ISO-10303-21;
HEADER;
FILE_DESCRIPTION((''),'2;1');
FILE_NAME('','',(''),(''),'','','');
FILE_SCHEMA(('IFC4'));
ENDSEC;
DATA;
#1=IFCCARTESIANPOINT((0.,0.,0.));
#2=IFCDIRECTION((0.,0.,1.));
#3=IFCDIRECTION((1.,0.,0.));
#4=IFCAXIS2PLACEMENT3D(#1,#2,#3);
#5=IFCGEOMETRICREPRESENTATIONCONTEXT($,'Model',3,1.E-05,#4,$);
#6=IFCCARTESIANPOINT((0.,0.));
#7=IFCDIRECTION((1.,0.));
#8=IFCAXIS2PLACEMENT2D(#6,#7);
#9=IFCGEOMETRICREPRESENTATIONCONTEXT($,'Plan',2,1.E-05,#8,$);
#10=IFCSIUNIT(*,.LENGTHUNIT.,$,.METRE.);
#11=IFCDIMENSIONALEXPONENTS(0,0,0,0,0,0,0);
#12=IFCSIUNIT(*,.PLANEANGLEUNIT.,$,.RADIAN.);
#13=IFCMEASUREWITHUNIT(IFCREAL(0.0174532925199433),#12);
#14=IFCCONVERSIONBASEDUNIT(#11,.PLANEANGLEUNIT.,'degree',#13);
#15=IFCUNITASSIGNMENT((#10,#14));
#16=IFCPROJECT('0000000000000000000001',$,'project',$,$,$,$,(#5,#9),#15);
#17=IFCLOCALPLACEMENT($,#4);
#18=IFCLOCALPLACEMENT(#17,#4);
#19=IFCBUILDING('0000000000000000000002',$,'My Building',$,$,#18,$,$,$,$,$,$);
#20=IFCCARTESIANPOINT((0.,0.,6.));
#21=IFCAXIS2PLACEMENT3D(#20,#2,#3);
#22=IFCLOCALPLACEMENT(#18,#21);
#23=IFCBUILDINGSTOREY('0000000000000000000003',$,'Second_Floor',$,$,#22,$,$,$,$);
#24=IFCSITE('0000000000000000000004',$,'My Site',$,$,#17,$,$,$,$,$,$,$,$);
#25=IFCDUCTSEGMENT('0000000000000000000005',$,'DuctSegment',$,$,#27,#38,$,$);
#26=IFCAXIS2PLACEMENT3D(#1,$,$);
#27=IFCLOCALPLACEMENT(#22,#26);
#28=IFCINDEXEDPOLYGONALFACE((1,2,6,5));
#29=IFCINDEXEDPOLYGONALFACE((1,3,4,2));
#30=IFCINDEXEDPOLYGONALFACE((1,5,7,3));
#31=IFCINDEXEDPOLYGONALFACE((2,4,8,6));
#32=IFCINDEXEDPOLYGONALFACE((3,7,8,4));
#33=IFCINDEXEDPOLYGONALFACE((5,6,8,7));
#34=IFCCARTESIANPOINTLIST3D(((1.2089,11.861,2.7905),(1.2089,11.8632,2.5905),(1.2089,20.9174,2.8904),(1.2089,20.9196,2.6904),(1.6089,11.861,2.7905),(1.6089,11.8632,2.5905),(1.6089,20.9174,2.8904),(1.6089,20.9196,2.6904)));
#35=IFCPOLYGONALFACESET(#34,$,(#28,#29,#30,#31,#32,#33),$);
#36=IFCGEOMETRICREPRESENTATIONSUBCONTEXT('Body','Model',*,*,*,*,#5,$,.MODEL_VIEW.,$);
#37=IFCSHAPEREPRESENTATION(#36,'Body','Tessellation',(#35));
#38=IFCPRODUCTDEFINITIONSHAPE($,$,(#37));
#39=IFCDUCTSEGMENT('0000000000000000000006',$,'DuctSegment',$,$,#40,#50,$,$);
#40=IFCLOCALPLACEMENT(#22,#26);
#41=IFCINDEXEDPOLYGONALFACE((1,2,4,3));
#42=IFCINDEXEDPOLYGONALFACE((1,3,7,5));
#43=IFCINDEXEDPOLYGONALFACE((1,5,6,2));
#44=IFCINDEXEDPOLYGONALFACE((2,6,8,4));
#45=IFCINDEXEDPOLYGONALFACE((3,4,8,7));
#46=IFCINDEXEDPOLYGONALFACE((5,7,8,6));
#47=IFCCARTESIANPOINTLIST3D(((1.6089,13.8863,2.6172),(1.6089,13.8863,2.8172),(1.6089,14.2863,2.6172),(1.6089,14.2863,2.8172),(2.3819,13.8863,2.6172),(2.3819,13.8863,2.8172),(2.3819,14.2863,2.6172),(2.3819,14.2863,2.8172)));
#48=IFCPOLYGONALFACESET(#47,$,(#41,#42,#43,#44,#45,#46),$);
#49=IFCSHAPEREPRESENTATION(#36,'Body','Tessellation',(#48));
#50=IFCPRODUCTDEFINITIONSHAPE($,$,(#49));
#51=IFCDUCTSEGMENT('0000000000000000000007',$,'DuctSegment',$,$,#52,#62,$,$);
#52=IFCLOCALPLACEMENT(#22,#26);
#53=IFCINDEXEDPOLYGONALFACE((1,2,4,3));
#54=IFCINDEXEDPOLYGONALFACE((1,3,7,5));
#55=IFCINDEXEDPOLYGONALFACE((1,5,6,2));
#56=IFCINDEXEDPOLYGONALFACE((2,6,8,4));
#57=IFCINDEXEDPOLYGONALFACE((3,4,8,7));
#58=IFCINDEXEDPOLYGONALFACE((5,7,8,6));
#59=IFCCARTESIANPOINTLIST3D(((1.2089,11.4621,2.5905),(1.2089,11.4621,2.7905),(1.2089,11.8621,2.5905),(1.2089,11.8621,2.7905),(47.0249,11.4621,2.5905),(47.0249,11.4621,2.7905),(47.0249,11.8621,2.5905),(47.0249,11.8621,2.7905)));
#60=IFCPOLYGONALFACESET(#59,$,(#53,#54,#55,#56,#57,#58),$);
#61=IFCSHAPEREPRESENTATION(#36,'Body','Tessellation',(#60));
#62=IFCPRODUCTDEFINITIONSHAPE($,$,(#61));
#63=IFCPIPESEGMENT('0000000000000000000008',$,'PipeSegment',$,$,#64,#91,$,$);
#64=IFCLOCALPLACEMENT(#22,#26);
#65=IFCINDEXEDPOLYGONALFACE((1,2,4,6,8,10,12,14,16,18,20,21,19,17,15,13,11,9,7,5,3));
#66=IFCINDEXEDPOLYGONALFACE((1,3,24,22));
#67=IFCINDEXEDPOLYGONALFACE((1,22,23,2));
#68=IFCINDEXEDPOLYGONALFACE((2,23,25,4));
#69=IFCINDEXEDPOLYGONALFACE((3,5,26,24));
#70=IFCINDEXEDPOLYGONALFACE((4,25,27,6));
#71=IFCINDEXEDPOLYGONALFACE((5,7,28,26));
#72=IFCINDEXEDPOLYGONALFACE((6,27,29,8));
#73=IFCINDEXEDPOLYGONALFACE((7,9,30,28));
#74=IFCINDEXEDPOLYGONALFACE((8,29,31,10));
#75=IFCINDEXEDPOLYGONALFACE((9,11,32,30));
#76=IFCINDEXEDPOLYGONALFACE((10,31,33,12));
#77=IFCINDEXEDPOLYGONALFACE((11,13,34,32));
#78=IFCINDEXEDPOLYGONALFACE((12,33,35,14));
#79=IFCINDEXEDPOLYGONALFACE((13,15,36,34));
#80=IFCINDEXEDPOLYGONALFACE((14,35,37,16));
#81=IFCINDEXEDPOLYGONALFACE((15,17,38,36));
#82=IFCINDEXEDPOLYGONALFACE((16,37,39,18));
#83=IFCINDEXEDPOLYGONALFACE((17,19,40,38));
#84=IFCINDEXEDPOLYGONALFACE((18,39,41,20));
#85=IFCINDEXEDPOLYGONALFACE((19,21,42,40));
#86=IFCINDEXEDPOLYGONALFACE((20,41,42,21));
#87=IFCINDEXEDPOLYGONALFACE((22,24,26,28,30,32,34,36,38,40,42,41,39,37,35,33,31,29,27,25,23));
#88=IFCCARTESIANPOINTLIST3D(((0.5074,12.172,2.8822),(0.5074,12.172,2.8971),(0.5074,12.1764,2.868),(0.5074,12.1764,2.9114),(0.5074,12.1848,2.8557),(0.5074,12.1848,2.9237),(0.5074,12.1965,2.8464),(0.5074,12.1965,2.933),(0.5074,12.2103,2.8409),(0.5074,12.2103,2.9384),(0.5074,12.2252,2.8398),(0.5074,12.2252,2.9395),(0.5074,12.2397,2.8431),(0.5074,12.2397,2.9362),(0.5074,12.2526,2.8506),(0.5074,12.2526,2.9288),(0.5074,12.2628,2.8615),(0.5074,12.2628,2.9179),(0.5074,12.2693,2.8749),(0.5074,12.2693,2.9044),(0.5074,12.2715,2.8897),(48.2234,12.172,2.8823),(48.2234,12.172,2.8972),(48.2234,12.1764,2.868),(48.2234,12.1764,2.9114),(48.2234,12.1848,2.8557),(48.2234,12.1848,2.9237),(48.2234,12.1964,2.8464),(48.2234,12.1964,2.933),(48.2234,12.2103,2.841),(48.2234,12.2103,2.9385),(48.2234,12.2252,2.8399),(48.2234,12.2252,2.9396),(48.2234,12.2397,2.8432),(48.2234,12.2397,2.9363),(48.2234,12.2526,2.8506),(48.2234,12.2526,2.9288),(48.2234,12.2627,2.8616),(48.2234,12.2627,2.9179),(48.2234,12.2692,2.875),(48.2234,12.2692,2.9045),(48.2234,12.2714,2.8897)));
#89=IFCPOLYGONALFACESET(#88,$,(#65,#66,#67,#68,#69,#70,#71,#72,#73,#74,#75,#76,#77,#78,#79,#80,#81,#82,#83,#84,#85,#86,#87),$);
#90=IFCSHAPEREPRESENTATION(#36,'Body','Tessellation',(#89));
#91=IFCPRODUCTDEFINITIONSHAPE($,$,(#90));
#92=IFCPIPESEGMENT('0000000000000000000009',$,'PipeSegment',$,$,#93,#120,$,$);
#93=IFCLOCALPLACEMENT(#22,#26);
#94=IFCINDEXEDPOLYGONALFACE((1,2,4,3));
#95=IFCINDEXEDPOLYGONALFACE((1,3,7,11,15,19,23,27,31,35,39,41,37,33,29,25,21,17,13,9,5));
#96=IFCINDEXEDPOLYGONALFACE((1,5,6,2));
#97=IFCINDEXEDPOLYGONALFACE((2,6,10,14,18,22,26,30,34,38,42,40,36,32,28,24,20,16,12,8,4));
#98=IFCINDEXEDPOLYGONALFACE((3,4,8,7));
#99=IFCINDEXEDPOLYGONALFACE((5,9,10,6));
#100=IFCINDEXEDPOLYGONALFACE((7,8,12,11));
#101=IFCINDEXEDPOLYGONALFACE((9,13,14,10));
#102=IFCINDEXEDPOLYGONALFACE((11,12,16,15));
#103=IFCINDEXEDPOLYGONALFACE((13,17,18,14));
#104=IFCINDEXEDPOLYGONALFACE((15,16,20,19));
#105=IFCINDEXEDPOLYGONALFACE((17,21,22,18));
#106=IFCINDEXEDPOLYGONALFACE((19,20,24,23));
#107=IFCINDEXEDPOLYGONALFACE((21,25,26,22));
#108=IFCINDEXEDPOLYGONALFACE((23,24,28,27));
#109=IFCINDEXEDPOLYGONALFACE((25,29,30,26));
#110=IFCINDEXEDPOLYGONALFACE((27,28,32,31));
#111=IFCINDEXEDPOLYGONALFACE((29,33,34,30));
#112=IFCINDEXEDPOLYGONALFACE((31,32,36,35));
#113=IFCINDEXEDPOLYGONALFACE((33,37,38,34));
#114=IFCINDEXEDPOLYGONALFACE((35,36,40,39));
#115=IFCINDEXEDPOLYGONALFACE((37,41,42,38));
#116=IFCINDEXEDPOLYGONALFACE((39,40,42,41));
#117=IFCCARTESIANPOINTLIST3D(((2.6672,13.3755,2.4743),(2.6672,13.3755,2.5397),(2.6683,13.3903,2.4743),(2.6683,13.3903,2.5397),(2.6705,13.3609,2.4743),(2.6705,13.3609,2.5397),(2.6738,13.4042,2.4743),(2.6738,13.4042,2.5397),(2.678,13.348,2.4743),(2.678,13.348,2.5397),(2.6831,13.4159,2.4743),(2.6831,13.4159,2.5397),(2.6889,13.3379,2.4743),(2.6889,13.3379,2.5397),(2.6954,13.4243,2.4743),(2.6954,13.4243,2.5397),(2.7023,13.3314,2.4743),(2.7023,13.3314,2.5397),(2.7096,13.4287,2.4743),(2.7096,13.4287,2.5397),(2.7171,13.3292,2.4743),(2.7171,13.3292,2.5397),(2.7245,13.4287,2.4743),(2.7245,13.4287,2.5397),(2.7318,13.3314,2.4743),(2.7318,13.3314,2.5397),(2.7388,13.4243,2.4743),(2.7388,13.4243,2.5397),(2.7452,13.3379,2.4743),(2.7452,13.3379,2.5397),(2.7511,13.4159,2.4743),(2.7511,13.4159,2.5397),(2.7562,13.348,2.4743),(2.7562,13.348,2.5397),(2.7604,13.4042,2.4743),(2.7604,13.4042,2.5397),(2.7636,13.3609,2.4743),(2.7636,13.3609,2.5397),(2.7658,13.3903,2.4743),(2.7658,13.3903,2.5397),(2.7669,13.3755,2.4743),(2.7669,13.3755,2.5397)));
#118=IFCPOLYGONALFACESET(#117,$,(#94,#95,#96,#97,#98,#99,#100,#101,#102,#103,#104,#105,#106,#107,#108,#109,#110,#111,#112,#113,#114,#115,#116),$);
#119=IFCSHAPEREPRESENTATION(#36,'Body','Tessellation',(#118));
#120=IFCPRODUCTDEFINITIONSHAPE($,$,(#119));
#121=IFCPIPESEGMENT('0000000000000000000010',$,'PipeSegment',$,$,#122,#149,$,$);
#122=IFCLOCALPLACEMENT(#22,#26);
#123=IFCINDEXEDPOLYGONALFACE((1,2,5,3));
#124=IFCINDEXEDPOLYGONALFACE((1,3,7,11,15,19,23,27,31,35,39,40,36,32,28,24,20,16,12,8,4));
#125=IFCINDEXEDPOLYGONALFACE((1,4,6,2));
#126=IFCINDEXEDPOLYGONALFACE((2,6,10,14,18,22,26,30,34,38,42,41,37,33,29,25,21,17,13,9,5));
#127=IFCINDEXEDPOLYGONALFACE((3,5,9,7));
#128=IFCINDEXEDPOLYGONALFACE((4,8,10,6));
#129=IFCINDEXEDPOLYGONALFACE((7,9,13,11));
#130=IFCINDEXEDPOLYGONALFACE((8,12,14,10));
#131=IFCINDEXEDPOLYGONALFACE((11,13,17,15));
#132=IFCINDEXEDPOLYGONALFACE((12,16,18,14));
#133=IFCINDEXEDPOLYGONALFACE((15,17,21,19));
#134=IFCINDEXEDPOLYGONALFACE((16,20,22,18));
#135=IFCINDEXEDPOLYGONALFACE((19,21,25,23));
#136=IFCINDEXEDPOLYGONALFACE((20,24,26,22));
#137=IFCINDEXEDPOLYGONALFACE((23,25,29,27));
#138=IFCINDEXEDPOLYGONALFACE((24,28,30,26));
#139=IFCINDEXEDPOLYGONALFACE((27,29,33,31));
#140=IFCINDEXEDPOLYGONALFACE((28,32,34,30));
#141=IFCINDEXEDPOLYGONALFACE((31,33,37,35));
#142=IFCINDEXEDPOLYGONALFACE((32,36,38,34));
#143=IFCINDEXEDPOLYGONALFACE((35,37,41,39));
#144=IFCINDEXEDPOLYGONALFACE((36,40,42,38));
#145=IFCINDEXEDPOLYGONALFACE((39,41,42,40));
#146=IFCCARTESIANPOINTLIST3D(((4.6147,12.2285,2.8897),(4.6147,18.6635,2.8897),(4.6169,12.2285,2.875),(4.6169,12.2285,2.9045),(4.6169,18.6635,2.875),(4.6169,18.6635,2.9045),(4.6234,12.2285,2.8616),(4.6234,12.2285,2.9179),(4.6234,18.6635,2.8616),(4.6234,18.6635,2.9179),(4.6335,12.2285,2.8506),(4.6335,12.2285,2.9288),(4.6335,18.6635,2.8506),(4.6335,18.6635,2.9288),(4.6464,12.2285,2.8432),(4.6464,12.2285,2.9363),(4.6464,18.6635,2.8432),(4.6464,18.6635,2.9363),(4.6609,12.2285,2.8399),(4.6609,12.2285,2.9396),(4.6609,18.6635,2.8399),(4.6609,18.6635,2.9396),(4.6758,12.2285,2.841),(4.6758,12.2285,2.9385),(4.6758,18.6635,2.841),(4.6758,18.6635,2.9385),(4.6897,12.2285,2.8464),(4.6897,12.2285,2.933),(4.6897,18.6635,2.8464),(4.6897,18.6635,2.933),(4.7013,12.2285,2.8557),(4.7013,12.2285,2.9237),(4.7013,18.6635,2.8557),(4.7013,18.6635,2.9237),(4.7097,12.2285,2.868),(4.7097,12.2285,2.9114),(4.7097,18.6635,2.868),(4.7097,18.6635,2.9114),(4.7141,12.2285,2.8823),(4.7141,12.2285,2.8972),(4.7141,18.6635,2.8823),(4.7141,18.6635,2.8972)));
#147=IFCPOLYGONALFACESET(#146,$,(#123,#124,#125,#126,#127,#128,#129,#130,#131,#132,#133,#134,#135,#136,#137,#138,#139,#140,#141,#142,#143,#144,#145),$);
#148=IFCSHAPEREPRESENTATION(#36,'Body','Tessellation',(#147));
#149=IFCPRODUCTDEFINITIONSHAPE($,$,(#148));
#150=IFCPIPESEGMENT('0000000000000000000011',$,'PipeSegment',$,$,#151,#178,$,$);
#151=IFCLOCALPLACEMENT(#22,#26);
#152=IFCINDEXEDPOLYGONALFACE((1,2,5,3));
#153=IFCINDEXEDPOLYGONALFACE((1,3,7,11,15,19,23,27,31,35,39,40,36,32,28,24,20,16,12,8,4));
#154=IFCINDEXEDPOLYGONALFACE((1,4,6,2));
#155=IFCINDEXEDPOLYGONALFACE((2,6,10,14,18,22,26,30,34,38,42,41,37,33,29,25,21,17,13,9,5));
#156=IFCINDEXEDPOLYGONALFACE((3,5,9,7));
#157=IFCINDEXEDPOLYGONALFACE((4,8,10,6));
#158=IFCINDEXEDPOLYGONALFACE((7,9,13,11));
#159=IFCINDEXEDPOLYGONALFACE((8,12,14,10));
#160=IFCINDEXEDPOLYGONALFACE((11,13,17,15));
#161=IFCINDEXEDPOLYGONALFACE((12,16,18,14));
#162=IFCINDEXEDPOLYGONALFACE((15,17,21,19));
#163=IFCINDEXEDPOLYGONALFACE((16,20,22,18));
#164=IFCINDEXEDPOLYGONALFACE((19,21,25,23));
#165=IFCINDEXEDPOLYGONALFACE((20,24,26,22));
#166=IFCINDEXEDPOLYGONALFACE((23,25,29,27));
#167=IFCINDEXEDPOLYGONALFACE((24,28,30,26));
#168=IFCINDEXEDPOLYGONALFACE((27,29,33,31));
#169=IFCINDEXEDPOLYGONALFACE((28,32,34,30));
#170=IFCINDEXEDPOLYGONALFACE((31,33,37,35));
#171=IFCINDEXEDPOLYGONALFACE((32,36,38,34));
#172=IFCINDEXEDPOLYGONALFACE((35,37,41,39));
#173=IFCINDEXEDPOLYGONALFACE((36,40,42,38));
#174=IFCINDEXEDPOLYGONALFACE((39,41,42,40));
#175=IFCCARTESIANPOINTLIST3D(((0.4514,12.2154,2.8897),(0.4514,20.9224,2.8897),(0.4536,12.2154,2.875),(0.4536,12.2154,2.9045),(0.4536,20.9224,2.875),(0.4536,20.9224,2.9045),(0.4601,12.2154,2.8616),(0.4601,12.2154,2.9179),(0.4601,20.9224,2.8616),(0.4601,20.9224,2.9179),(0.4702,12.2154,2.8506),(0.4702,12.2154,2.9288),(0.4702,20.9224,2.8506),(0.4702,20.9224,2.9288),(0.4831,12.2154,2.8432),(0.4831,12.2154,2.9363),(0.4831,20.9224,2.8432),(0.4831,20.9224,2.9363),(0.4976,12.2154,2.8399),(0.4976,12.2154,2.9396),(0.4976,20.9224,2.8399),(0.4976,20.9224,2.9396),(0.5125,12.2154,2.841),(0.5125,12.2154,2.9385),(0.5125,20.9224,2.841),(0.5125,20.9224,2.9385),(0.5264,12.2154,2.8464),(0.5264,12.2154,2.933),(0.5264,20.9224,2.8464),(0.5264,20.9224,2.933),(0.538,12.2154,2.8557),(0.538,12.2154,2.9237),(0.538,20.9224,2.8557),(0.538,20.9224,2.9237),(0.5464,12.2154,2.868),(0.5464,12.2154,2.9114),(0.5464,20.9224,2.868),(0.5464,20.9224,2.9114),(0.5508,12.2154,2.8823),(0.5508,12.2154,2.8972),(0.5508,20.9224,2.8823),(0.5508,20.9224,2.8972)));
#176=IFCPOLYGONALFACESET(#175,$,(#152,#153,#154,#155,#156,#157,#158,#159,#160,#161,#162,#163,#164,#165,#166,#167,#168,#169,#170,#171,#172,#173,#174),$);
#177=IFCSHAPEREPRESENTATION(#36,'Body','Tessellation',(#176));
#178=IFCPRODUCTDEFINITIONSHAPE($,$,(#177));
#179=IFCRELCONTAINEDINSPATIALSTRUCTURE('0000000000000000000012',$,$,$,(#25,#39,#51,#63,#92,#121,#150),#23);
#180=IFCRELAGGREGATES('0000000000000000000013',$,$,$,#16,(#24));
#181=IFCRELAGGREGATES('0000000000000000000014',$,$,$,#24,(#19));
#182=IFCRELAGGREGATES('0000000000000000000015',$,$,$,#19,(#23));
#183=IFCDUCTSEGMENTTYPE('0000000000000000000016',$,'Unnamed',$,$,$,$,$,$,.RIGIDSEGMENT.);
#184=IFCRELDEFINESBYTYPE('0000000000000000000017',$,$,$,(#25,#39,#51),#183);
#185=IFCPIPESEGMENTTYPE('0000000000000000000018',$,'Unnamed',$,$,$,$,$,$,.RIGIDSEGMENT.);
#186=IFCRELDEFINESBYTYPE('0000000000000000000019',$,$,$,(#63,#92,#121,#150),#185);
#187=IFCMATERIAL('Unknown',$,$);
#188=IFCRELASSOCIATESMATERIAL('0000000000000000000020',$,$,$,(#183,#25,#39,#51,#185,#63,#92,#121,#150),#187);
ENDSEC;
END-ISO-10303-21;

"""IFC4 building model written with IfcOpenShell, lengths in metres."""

from ifc_helpers import new_model, entity, si_unit, converted_unit, frame, origin_with_axes, origin_2d_with_axis, place, context, subcontext, project, spatial, rectangle, circle, extrude, material, material_profile, profile_set, profile_usage, type_object, element, save


model = new_model("IFC4")

# Units and contexts
model_context = context("Model", 3, precision=1e-05, world=origin_with_axes())
plan_context = context("Plan", 2, precision=1e-05, world=origin_2d_with_axis())
body_context_1 = subcontext(model_context, "Body", "Model", "MODEL_VIEW")
ifc_project = project(units=[si_unit("LENGTHUNIT", "METRE"), converted_unit("PLANEANGLEUNIT", "degree", entity("IfcReal", 0.0174532925199433), si_unit("PLANEANGLEUNIT", "RADIAN"), dimensions=[0, 0, 0, 0, 0, 0, 0])], contexts=[model_context, plan_context])

# Site, building, storey
site_placement = place(None, origin_with_axes())
site = spatial("IfcSite", under=ifc_project, at=site_placement, Name="My Site")
building_placement = place(site_placement, origin_with_axes())
building = spatial("IfcBuilding", under=site, at=building_placement, Name="My Building")
storey_placement = place(building_placement, frame((0.0, 0.0, 6.0), z_axis=(0.0, 0.0, 1.0), x_axis=(1.0, 0.0, 0.0)))
storey = spatial("IfcBuildingStorey", under=building, at=storey_placement, Name="Second_Floor")

# Shared definitions
ifc_material = material(Name="Unknown")

# Duct segments
ifc_material_profile_1 = material_profile(ifc_material, rectangle(XDim=0.4, YDim=0.2))
ifc_profile_set_1 = profile_set([ifc_material_profile_1])
ifc_profile_usage_1 = profile_usage(ifc_profile_set_1, cardinal=5)
duct_segment_type = type_object("IfcDuctSegmentType", Name="Unnamed", PredefinedType="RIGIDSEGMENT", material=ifc_profile_set_1)
duct_segment_1_placement = place(storey_placement, frame((1.4089, 11.8621, 2.6905), z_axis=(0.0, 0.999939, 0.011037), x_axis=(-1.0, 0.0, 0.0)))
element("IfcDuctSegment", 1, at=duct_segment_1_placement, inside=storey, type_object=duct_segment_type, material=ifc_profile_usage_1, Name="DuctSegment", context=body_context_1, shape_type="SweptSolid", body=[
    extrude(rectangle(XDim=0.4, YDim=0.2), origin_with_axes(), (0.0, 0.0, 1.0), 9.057),
])
ifc_profile_usage_2 = profile_usage(ifc_profile_set_1, cardinal=5)
duct_segment_2_placement = place(storey_placement, frame((1.6089, 14.0863, 2.7172), z_axis=(1.0, -0.000001, 0.000001), x_axis=(0.000001, 1.0, 0.0)))
element("IfcDuctSegment", 2, at=duct_segment_2_placement, inside=storey, type_object=duct_segment_type, material=ifc_profile_usage_2, Name="DuctSegment", context=body_context_1, shape_type="SweptSolid", body=[
    extrude(rectangle(XDim=0.4, YDim=0.2), origin_with_axes(), (0.0, 0.0, 1.0), 0.773),
])
ifc_profile_usage_3 = profile_usage(ifc_profile_set_1, cardinal=5)
duct_segment_3_placement = place(storey_placement, frame((1.2089, 11.6621, 2.6905), z_axis=(1.0, 0.0, 0.0), x_axis=(0.0, 1.0, 0.0)))
element("IfcDuctSegment", 3, at=duct_segment_3_placement, inside=storey, type_object=duct_segment_type, material=ifc_profile_usage_3, Name="DuctSegment", context=body_context_1, shape_type="SweptSolid", body=[
    extrude(rectangle(XDim=0.4, YDim=0.2), origin_with_axes(), (0.0, 0.0, 1.0), 45.816),
])

# Pipe segments
ifc_material_profile_2 = material_profile(ifc_material, circle(Radius=0.05))
ifc_profile_set_2 = profile_set([ifc_material_profile_2])
ifc_profile_usage_4 = profile_usage(ifc_profile_set_2, cardinal=5)
pipe_segment_type = type_object("IfcPipeSegmentType", Name="Unnamed", PredefinedType="RIGIDSEGMENT", material=ifc_profile_set_2)
pipe_segment_1_placement = place(storey_placement, frame((0.5074, 12.2215, 2.8897), z_axis=(1.0, -0.000001, 0.000001), x_axis=(0.000001, 1.0, 0.0)))
element("IfcPipeSegment", 4, at=pipe_segment_1_placement, inside=storey, type_object=pipe_segment_type, material=ifc_profile_usage_4, Name="PipeSegment", context=body_context_1, shape_type="SweptSolid", body=[
    extrude(circle(Radius=0.05), origin_with_axes(), (0.0, 0.0, 1.0), 47.716),
])
ifc_profile_usage_5 = profile_usage(ifc_profile_set_2, cardinal=5)
pipe_segment_2_placement = place(storey_placement, frame((2.7171, 13.3792, 2.4743), z_axis=(0.0, 0.0, 1.0), x_axis=(0.000001, -1.0, 0.0)))
element("IfcPipeSegment", 5, at=pipe_segment_2_placement, inside=storey, type_object=pipe_segment_type, material=ifc_profile_usage_5, Name="PipeSegment", context=body_context_1, shape_type="SweptSolid", body=[
    extrude(circle(Radius=0.05), origin_with_axes(), (0.0, 0.0, 1.0), 0.0654),
])
ifc_profile_usage_6 = profile_usage(ifc_profile_set_2, cardinal=5)
pipe_segment_3_placement = place(storey_placement, frame((4.6647, 12.2285, 2.8897), z_axis=(0.0, 1.0, 0.0), x_axis=(-1.0, 0.0, 0.0)))
element("IfcPipeSegment", 6, at=pipe_segment_3_placement, inside=storey, type_object=pipe_segment_type, material=ifc_profile_usage_6, Name="PipeSegment", context=body_context_1, shape_type="SweptSolid", body=[
    extrude(circle(Radius=0.05), origin_with_axes(), (0.0, 0.0, 1.0), 6.435),
])
ifc_profile_usage_7 = profile_usage(ifc_profile_set_2, cardinal=5)
pipe_segment_4_placement = place(storey_placement, frame((0.5014, 12.2154, 2.8897), z_axis=(0.0, 1.0, 0.0), x_axis=(-1.0, 0.0, 0.0)))
element("IfcPipeSegment", 7, at=pipe_segment_4_placement, inside=storey, type_object=pipe_segment_type, material=ifc_profile_usage_7, Name="PipeSegment", context=body_context_1, shape_type="SweptSolid", body=[
    extrude(circle(Radius=0.05), origin_with_axes(), (0.0, 0.0, 1.0), 8.707),
])

save(model, "model.ifc")
